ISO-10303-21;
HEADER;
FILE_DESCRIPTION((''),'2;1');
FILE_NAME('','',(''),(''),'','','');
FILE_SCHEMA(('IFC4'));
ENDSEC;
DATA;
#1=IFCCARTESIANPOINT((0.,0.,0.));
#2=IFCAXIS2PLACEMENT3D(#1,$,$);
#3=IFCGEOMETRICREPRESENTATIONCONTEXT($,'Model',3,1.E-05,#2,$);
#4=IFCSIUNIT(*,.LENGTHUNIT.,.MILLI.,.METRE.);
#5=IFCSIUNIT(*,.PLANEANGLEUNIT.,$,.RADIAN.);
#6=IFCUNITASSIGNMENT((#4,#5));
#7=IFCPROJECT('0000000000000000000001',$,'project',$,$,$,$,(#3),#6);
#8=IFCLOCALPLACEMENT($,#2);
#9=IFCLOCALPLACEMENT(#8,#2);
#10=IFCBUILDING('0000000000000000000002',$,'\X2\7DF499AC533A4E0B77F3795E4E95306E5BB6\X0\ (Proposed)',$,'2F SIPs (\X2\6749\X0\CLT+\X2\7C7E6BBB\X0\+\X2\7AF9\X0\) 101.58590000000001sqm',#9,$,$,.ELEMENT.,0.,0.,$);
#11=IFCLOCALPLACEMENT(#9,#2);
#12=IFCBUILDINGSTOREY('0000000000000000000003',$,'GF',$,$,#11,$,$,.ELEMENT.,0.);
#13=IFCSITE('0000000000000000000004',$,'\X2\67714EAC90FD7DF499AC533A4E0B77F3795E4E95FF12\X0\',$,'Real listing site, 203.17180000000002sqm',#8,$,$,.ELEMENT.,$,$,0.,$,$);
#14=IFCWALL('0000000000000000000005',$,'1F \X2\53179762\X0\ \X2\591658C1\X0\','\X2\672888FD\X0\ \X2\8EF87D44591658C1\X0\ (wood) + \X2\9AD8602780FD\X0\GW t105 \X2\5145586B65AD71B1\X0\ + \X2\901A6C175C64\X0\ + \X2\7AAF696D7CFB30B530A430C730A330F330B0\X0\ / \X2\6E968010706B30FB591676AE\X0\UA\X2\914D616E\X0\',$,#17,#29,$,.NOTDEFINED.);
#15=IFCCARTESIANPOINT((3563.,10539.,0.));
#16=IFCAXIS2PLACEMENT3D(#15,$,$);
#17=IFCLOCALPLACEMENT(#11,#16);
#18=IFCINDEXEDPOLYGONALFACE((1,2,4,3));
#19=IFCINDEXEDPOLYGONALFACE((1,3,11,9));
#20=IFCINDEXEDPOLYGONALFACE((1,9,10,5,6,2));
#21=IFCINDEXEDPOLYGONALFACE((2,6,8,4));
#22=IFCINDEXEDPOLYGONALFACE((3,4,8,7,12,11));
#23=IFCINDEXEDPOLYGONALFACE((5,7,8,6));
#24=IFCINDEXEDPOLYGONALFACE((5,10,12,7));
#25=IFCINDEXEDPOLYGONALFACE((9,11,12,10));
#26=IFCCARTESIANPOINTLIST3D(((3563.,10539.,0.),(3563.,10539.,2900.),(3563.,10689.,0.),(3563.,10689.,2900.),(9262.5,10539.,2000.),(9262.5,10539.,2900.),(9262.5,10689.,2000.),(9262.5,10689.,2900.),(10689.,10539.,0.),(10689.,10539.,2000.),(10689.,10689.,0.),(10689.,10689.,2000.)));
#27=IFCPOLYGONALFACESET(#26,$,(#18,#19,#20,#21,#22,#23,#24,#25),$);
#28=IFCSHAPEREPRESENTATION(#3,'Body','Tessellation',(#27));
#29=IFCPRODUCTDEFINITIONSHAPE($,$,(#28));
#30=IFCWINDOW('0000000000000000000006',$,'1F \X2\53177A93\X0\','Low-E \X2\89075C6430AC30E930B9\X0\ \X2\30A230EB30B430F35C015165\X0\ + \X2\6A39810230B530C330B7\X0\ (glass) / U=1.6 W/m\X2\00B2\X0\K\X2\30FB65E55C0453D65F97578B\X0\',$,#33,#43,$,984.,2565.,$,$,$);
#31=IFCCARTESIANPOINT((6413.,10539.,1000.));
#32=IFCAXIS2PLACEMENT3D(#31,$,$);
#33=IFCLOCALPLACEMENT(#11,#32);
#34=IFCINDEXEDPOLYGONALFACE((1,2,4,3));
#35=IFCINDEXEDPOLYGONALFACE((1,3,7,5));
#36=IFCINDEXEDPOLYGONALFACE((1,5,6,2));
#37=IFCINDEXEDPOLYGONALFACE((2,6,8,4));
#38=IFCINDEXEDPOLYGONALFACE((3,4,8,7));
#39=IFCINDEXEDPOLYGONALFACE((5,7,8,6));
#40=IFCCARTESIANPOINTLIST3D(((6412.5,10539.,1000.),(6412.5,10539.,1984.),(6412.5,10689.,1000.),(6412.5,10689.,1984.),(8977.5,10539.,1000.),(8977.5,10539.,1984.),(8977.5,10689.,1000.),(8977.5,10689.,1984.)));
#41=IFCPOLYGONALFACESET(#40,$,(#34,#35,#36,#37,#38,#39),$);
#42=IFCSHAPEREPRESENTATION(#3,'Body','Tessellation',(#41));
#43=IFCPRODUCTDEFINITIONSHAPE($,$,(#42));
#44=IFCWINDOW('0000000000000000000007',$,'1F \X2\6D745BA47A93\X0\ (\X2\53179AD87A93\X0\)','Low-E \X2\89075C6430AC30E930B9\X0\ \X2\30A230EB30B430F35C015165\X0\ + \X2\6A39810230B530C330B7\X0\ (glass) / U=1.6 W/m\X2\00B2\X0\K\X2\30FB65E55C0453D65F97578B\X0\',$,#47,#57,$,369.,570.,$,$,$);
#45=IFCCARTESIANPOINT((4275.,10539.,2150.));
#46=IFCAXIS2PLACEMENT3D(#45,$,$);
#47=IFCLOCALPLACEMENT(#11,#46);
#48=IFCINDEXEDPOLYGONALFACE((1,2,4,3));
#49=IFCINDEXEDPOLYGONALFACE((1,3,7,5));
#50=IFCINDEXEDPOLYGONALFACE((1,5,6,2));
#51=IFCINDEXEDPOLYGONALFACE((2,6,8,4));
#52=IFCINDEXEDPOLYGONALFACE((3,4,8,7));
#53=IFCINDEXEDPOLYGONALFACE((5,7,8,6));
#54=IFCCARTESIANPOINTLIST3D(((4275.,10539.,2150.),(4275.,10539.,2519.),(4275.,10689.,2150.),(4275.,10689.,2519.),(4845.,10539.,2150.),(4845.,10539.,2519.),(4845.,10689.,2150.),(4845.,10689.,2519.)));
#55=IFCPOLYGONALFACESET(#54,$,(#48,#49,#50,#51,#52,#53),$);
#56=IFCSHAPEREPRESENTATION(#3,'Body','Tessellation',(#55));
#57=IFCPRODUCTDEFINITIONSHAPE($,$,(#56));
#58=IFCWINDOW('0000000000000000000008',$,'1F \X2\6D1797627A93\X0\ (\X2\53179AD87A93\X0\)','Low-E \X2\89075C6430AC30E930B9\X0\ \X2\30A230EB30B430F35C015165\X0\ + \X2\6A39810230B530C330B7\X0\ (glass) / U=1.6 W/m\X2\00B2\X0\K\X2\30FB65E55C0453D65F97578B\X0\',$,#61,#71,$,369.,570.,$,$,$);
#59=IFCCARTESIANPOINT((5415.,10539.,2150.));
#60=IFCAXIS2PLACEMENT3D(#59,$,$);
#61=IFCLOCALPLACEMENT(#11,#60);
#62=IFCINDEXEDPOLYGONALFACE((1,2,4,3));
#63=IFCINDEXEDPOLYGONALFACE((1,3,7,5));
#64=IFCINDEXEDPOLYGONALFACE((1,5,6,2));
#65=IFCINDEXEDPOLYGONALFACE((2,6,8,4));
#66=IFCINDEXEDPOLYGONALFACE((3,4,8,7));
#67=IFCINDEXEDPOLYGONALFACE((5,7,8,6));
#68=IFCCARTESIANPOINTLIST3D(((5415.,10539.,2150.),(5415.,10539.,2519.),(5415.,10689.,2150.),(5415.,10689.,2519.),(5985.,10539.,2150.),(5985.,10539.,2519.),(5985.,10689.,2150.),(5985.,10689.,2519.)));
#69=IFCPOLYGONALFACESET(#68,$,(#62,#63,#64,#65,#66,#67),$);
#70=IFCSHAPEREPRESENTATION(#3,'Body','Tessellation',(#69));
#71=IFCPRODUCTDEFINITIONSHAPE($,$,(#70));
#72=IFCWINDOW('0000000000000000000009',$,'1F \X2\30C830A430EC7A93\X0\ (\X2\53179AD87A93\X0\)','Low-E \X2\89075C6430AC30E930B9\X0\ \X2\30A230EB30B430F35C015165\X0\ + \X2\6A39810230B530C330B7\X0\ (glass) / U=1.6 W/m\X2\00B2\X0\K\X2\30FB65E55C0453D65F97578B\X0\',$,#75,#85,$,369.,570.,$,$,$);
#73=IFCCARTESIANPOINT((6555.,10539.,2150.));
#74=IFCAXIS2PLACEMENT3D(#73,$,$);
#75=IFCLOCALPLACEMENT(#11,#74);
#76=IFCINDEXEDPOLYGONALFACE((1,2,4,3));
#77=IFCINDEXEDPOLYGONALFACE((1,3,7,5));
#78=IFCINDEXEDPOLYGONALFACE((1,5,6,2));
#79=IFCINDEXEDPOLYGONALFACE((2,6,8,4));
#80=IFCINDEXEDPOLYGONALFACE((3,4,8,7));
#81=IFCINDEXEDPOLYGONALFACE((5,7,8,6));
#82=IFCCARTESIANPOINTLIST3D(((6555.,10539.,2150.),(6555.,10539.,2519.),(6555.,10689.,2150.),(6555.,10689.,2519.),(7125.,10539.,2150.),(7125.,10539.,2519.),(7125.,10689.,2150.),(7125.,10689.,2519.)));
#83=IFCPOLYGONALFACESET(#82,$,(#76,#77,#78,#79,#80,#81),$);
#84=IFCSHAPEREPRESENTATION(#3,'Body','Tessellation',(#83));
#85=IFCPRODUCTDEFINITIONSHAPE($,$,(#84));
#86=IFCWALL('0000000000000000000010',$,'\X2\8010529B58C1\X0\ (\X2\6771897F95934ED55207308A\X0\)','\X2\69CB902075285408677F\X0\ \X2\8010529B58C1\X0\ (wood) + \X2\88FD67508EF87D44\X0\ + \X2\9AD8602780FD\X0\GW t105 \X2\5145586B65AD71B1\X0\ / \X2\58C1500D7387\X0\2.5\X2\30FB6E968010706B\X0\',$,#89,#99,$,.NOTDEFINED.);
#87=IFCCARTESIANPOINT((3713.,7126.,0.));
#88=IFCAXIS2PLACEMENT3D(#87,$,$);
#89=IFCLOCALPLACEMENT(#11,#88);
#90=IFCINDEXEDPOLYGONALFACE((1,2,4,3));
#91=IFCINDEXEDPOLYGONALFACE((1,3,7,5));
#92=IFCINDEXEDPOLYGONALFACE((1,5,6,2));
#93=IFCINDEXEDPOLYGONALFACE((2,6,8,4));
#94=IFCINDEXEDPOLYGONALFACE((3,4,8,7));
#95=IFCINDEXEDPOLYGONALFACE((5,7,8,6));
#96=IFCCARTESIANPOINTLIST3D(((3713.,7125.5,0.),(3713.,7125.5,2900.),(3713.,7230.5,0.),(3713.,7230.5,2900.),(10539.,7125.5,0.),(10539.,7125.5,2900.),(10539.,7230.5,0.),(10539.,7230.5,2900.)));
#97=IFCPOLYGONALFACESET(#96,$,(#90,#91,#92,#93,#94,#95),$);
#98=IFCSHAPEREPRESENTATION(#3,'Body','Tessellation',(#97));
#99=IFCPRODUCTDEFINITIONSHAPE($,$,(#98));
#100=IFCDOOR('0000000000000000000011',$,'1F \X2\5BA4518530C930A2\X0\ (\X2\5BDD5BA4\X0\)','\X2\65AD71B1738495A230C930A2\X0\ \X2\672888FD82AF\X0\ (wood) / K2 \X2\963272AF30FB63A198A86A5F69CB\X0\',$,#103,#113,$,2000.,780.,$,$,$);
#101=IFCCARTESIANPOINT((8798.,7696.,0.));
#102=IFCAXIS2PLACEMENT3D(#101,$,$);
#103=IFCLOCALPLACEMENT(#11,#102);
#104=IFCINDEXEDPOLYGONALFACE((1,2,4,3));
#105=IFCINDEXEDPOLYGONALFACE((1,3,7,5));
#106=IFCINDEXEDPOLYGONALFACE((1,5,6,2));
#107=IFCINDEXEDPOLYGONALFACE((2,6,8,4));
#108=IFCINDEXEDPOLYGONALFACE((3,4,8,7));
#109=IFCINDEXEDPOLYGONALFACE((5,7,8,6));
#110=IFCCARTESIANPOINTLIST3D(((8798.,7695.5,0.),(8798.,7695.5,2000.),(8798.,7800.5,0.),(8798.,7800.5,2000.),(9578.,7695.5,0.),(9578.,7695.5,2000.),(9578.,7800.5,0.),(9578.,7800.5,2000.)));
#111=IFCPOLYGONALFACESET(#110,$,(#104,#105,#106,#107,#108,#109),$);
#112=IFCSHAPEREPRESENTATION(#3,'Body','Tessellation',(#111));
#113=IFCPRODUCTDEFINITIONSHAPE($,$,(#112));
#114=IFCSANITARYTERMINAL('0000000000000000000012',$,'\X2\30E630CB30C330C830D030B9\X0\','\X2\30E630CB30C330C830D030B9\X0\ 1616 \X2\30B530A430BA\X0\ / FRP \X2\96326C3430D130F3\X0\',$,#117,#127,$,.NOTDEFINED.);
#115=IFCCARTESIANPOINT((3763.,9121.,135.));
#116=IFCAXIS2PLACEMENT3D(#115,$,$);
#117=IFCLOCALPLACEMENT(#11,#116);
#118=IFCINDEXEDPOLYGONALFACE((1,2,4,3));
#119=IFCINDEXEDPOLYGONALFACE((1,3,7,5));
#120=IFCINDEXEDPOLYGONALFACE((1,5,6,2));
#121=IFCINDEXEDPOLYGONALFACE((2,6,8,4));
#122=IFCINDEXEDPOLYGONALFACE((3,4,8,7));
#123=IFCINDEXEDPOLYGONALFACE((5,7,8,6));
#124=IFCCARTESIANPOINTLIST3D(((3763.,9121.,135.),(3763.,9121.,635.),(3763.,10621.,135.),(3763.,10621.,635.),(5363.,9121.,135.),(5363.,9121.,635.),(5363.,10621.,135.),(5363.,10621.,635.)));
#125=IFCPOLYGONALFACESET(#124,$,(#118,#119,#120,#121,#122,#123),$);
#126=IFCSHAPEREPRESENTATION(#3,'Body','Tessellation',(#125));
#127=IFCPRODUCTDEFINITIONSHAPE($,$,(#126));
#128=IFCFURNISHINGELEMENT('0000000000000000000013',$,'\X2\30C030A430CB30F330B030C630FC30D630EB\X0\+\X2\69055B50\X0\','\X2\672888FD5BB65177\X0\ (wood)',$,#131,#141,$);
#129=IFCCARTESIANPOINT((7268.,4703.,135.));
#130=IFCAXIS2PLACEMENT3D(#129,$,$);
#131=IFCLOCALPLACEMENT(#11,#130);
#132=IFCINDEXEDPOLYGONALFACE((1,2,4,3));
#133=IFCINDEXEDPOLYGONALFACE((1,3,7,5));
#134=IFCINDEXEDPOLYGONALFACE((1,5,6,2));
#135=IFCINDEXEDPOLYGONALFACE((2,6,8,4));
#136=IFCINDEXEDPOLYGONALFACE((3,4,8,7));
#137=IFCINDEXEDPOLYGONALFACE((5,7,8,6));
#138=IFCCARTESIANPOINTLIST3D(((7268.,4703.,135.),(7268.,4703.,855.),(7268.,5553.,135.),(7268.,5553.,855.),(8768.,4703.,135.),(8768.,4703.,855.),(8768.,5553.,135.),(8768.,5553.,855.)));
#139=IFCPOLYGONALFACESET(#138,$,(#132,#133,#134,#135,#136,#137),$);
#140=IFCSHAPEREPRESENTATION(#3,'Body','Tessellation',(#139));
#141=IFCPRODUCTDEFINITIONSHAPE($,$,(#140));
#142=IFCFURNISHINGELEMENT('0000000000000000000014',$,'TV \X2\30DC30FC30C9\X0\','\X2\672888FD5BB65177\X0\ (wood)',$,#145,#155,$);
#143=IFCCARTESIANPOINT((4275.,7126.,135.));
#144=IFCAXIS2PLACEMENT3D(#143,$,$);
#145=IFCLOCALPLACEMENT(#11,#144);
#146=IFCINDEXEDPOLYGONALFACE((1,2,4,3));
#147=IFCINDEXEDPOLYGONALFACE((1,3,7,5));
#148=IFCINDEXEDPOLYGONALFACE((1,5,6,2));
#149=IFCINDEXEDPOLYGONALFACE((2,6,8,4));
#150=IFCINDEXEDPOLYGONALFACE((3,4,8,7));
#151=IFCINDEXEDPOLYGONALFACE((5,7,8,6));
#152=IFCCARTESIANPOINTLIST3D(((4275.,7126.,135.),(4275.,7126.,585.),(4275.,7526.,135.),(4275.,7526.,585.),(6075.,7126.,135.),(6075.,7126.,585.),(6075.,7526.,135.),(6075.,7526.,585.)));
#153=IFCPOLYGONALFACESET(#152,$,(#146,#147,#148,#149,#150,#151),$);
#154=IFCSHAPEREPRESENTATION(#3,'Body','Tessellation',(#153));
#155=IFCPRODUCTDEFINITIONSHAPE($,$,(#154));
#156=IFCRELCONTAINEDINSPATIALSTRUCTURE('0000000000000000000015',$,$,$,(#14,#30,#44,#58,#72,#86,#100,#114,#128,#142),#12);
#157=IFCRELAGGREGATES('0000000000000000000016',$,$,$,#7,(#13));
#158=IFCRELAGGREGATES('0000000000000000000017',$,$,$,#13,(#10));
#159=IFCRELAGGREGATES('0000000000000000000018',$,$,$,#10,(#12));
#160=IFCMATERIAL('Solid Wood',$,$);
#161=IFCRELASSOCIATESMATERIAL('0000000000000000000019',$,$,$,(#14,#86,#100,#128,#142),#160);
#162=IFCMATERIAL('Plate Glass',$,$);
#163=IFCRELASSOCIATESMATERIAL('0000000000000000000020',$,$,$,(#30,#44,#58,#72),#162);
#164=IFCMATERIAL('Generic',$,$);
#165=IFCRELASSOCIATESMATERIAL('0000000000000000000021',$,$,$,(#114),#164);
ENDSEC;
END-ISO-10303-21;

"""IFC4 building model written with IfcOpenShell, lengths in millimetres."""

from ifc_helpers import new_model, si_unit, frame, frame_2d, origin, place, context, project, spatial, rectangle, extrude, material, element, fill, save


model = new_model("IFC4")

# Units and contexts
model_context = context("Model", 3, precision=1e-05, world=origin())
ifc_project = project(units=[si_unit("LENGTHUNIT", "METRE", prefix="MILLI"), si_unit("PLANEANGLEUNIT", "RADIAN")], contexts=[model_context])

# Site, building, storey
site_placement = place(None, origin())
site = spatial("IfcSite", under=ifc_project, at=site_placement, Name="東京都練馬区下石神井２", ObjectType="Real listing site, 203.17180000000002sqm", CompositionType="ELEMENT", RefElevation=0.0)
building_placement = place(site_placement, origin())
building = spatial("IfcBuilding", under=site, at=building_placement, Name="練馬区下石神井の家 (Proposed)", ObjectType="2F SIPs (杉CLT+籾殻+竹) 101.58590000000001sqm", CompositionType="ELEMENT", ElevationOfRefHeight=0.0, ElevationOfTerrain=0.0)
storey_placement = place(building_placement, origin())
storey = spatial("IfcBuildingStorey", under=building, at=storey_placement, Name="GF", CompositionType="ELEMENT", Elevation=0.0)

# Wall, openings, windows
ifc_material_1 = material(Name="Solid Wood")
wall_1_placement = place(storey_placement, frame((3563.0, 10539.0, 0.0)))
wall_1 = element("IfcWall", 1, at=wall_1_placement, inside=storey, material=ifc_material_1, Name="1F 北面 外壁", Description="木製 軸組外壁 (wood) + 高性能GW t105 充填断熱 + 通気層 + 窯業系サイディング / 準耐火・外皮UA配慮", PredefinedType="NOTDEFINED", context=model_context, shape_type="SweptSolid", body=[
    extrude(rectangle(XDim=7126.0, YDim=150.0, at=frame_2d((3563.0, 75.0))), frame((3563.0, 10539.0, 0.0)), (0.0, 0.0, 1.0), 2900.0),
])
opening_1_placement = place(storey_placement, frame((6413.0, 10539.0, 1000.0)))
opening_1 = element("IfcOpeningElement", 2, at=opening_1_placement, cuts=wall_1, PredefinedType="NOTDEFINED", context=model_context, shape_type="SweptSolid", body=[
    extrude(rectangle(XDim=2565.0, YDim=150.0, at=frame_2d((1282.0, 75.0))), frame((6413.0, 10539.0, 1000.0)), (0.0, 0.0, 1.0), 984.0),
])
opening_2_placement = place(storey_placement, frame((4275.0, 10539.0, 2150.0)))
opening_2 = element("IfcOpeningElement", 3, at=opening_2_placement, cuts=wall_1, PredefinedType="NOTDEFINED", context=model_context, shape_type="SweptSolid", body=[
    extrude(rectangle(XDim=570.0, YDim=150.0, at=frame_2d((285.0, 75.0))), frame((4275.0, 10539.0, 2150.0)), (0.0, 0.0, 1.0), 369.0),
])
opening_3_placement = place(storey_placement, frame((5415.0, 10539.0, 2150.0)))
opening_3 = element("IfcOpeningElement", 4, at=opening_3_placement, cuts=wall_1, PredefinedType="NOTDEFINED", context=model_context, shape_type="SweptSolid", body=[
    extrude(rectangle(XDim=570.0, YDim=150.0, at=frame_2d((285.0, 75.0))), frame((5415.0, 10539.0, 2150.0)), (0.0, 0.0, 1.0), 369.0),
])
opening_4_placement = place(storey_placement, frame((6555.0, 10539.0, 2150.0)))
opening_4 = element("IfcOpeningElement", 5, at=opening_4_placement, cuts=wall_1, PredefinedType="NOTDEFINED", context=model_context, shape_type="SweptSolid", body=[
    extrude(rectangle(XDim=570.0, YDim=150.0, at=frame_2d((285.0, 75.0))), frame((6555.0, 10539.0, 2150.0)), (0.0, 0.0, 1.0), 369.0),
])
ifc_material_2 = material(Name="Plate Glass")
window_1_placement = place(storey_placement, frame((6413.0, 10539.0, 1000.0)))
window_1 = element("IfcWindow", 6, at=window_1_placement, inside=storey, material=ifc_material_2, Name="1F 北窓", Description="Low-E 複層ガラス アルゴン封入 + 樹脂サッシ (glass) / U=1.6 W/m²K・日射取得型", OverallHeight=984.0, OverallWidth=2565.0, context=model_context, shape_type="SweptSolid", body=[
    extrude(rectangle(XDim=2565.0, YDim=150.0, at=frame_2d((1282.0, 75.0))), frame((6413.0, 10539.0, 1000.0)), (0.0, 0.0, 1.0), 984.0),
])
fill(opening_1, window_1)
window_2_placement = place(storey_placement, frame((4275.0, 10539.0, 2150.0)))
window_2 = element("IfcWindow", 7, at=window_2_placement, inside=storey, material=ifc_material_2, Name="1F 浴室窓 (北高窓)", Description="Low-E 複層ガラス アルゴン封入 + 樹脂サッシ (glass) / U=1.6 W/m²K・日射取得型", OverallHeight=369.0, OverallWidth=570.0, context=model_context, shape_type="SweptSolid", body=[
    extrude(rectangle(XDim=570.0, YDim=150.0, at=frame_2d((285.0, 75.0))), frame((4275.0, 10539.0, 2150.0)), (0.0, 0.0, 1.0), 369.0),
])
fill(opening_2, window_2)
window_3_placement = place(storey_placement, frame((5415.0, 10539.0, 2150.0)))
window_3 = element("IfcWindow", 8, at=window_3_placement, inside=storey, material=ifc_material_2, Name="1F 洗面窓 (北高窓)", Description="Low-E 複層ガラス アルゴン封入 + 樹脂サッシ (glass) / U=1.6 W/m²K・日射取得型", OverallHeight=369.0, OverallWidth=570.0, context=model_context, shape_type="SweptSolid", body=[
    extrude(rectangle(XDim=570.0, YDim=150.0, at=frame_2d((285.0, 75.0))), frame((5415.0, 10539.0, 2150.0)), (0.0, 0.0, 1.0), 369.0),
])
fill(opening_3, window_3)
window_4_placement = place(storey_placement, frame((6555.0, 10539.0, 2150.0)))
window_4 = element("IfcWindow", 9, at=window_4_placement, inside=storey, material=ifc_material_2, Name="1F トイレ窓 (北高窓)", Description="Low-E 複層ガラス アルゴン封入 + 樹脂サッシ (glass) / U=1.6 W/m²K・日射取得型", OverallHeight=369.0, OverallWidth=570.0, context=model_context, shape_type="SweptSolid", body=[
    extrude(rectangle(XDim=570.0, YDim=150.0, at=frame_2d((285.0, 75.0))), frame((6555.0, 10539.0, 2150.0)), (0.0, 0.0, 1.0), 369.0),
])
fill(opening_4, window_4)

# Wall
wall_2_placement = place(storey_placement, frame((3713.0, 7126.0, 0.0)))
element("IfcWall", 10, at=wall_2_placement, inside=storey, material=ifc_material_1, Name="耐力壁 (東西間仕切り)", Description="構造用合板 耐力壁 (wood) + 製材軸組 + 高性能GW t105 充填断熱 / 壁倍率2.5・準耐火", PredefinedType="NOTDEFINED", context=model_context, shape_type="SweptSolid", body=[
    extrude(rectangle(XDim=6826.0, YDim=105.0, at=frame_2d((3413.0, 52.0))), frame((3713.0, 7126.0, 0.0)), (0.0, 0.0, 1.0), 2900.0),
])

# Door
door_1_placement = place(storey_placement, frame((8798.0, 7696.0, 0.0)))
element("IfcDoor", 11, at=door_1_placement, inside=storey, material=ifc_material_1, Name="1F 室内ドア (寝室)", Description="断熱玄関ドア 木製芯 (wood) / K2 防犯・採風機構", OverallHeight=2000.0, OverallWidth=780.0, context=model_context, shape_type="SweptSolid", body=[
    extrude(rectangle(XDim=780.0, YDim=105.0, at=frame_2d((390.0, 52.0))), frame((8798.0, 7696.0, 0.0)), (0.0, 0.0, 1.0), 2000.0),
])

# Sanitary terminal
ifc_material_3 = material(Name="Generic")
sanitary_terminal_placement = place(storey_placement, frame((3763.0, 9121.0, 135.0)))
element("IfcSanitaryTerminal", 12, at=sanitary_terminal_placement, inside=storey, material=ifc_material_3, Name="ユニットバス", Description="ユニットバス 1616 サイズ / FRP 防水パン", PredefinedType="NOTDEFINED", context=model_context, shape_type="SweptSolid", body=[
    extrude(rectangle(XDim=1600.0, YDim=1500.0, at=frame_2d((800.0, 750.0))), frame((3763.0, 9121.0, 135.0)), (0.0, 0.0, 1.0), 500.0),
])

# Furnishing elements
furnishing_1_placement = place(storey_placement, frame((7268.0, 4703.0, 135.0)))
element("IfcFurnishingElement", 13, at=furnishing_1_placement, inside=storey, material=ifc_material_1, Name="ダイニングテーブル+椅子", Description="木製家具 (wood)", context=model_context, shape_type="SweptSolid", body=[
    extrude(rectangle(XDim=1500.0, YDim=850.0, at=frame_2d((750.0, 425.0))), frame((7268.0, 4703.0, 135.0)), (0.0, 0.0, 1.0), 720.0),
])
furnishing_2_placement = place(storey_placement, frame((4275.0, 7126.0, 135.0)))
element("IfcFurnishingElement", 14, at=furnishing_2_placement, inside=storey, material=ifc_material_1, Name="TV ボード", Description="木製家具 (wood)", context=model_context, shape_type="SweptSolid", body=[
    extrude(rectangle(XDim=1800.0, YDim=400.0, at=frame_2d((900.0, 200.0))), frame((4275.0, 7126.0, 135.0)), (0.0, 0.0, 1.0), 450.0),
])

save(model, "model.ifc")
